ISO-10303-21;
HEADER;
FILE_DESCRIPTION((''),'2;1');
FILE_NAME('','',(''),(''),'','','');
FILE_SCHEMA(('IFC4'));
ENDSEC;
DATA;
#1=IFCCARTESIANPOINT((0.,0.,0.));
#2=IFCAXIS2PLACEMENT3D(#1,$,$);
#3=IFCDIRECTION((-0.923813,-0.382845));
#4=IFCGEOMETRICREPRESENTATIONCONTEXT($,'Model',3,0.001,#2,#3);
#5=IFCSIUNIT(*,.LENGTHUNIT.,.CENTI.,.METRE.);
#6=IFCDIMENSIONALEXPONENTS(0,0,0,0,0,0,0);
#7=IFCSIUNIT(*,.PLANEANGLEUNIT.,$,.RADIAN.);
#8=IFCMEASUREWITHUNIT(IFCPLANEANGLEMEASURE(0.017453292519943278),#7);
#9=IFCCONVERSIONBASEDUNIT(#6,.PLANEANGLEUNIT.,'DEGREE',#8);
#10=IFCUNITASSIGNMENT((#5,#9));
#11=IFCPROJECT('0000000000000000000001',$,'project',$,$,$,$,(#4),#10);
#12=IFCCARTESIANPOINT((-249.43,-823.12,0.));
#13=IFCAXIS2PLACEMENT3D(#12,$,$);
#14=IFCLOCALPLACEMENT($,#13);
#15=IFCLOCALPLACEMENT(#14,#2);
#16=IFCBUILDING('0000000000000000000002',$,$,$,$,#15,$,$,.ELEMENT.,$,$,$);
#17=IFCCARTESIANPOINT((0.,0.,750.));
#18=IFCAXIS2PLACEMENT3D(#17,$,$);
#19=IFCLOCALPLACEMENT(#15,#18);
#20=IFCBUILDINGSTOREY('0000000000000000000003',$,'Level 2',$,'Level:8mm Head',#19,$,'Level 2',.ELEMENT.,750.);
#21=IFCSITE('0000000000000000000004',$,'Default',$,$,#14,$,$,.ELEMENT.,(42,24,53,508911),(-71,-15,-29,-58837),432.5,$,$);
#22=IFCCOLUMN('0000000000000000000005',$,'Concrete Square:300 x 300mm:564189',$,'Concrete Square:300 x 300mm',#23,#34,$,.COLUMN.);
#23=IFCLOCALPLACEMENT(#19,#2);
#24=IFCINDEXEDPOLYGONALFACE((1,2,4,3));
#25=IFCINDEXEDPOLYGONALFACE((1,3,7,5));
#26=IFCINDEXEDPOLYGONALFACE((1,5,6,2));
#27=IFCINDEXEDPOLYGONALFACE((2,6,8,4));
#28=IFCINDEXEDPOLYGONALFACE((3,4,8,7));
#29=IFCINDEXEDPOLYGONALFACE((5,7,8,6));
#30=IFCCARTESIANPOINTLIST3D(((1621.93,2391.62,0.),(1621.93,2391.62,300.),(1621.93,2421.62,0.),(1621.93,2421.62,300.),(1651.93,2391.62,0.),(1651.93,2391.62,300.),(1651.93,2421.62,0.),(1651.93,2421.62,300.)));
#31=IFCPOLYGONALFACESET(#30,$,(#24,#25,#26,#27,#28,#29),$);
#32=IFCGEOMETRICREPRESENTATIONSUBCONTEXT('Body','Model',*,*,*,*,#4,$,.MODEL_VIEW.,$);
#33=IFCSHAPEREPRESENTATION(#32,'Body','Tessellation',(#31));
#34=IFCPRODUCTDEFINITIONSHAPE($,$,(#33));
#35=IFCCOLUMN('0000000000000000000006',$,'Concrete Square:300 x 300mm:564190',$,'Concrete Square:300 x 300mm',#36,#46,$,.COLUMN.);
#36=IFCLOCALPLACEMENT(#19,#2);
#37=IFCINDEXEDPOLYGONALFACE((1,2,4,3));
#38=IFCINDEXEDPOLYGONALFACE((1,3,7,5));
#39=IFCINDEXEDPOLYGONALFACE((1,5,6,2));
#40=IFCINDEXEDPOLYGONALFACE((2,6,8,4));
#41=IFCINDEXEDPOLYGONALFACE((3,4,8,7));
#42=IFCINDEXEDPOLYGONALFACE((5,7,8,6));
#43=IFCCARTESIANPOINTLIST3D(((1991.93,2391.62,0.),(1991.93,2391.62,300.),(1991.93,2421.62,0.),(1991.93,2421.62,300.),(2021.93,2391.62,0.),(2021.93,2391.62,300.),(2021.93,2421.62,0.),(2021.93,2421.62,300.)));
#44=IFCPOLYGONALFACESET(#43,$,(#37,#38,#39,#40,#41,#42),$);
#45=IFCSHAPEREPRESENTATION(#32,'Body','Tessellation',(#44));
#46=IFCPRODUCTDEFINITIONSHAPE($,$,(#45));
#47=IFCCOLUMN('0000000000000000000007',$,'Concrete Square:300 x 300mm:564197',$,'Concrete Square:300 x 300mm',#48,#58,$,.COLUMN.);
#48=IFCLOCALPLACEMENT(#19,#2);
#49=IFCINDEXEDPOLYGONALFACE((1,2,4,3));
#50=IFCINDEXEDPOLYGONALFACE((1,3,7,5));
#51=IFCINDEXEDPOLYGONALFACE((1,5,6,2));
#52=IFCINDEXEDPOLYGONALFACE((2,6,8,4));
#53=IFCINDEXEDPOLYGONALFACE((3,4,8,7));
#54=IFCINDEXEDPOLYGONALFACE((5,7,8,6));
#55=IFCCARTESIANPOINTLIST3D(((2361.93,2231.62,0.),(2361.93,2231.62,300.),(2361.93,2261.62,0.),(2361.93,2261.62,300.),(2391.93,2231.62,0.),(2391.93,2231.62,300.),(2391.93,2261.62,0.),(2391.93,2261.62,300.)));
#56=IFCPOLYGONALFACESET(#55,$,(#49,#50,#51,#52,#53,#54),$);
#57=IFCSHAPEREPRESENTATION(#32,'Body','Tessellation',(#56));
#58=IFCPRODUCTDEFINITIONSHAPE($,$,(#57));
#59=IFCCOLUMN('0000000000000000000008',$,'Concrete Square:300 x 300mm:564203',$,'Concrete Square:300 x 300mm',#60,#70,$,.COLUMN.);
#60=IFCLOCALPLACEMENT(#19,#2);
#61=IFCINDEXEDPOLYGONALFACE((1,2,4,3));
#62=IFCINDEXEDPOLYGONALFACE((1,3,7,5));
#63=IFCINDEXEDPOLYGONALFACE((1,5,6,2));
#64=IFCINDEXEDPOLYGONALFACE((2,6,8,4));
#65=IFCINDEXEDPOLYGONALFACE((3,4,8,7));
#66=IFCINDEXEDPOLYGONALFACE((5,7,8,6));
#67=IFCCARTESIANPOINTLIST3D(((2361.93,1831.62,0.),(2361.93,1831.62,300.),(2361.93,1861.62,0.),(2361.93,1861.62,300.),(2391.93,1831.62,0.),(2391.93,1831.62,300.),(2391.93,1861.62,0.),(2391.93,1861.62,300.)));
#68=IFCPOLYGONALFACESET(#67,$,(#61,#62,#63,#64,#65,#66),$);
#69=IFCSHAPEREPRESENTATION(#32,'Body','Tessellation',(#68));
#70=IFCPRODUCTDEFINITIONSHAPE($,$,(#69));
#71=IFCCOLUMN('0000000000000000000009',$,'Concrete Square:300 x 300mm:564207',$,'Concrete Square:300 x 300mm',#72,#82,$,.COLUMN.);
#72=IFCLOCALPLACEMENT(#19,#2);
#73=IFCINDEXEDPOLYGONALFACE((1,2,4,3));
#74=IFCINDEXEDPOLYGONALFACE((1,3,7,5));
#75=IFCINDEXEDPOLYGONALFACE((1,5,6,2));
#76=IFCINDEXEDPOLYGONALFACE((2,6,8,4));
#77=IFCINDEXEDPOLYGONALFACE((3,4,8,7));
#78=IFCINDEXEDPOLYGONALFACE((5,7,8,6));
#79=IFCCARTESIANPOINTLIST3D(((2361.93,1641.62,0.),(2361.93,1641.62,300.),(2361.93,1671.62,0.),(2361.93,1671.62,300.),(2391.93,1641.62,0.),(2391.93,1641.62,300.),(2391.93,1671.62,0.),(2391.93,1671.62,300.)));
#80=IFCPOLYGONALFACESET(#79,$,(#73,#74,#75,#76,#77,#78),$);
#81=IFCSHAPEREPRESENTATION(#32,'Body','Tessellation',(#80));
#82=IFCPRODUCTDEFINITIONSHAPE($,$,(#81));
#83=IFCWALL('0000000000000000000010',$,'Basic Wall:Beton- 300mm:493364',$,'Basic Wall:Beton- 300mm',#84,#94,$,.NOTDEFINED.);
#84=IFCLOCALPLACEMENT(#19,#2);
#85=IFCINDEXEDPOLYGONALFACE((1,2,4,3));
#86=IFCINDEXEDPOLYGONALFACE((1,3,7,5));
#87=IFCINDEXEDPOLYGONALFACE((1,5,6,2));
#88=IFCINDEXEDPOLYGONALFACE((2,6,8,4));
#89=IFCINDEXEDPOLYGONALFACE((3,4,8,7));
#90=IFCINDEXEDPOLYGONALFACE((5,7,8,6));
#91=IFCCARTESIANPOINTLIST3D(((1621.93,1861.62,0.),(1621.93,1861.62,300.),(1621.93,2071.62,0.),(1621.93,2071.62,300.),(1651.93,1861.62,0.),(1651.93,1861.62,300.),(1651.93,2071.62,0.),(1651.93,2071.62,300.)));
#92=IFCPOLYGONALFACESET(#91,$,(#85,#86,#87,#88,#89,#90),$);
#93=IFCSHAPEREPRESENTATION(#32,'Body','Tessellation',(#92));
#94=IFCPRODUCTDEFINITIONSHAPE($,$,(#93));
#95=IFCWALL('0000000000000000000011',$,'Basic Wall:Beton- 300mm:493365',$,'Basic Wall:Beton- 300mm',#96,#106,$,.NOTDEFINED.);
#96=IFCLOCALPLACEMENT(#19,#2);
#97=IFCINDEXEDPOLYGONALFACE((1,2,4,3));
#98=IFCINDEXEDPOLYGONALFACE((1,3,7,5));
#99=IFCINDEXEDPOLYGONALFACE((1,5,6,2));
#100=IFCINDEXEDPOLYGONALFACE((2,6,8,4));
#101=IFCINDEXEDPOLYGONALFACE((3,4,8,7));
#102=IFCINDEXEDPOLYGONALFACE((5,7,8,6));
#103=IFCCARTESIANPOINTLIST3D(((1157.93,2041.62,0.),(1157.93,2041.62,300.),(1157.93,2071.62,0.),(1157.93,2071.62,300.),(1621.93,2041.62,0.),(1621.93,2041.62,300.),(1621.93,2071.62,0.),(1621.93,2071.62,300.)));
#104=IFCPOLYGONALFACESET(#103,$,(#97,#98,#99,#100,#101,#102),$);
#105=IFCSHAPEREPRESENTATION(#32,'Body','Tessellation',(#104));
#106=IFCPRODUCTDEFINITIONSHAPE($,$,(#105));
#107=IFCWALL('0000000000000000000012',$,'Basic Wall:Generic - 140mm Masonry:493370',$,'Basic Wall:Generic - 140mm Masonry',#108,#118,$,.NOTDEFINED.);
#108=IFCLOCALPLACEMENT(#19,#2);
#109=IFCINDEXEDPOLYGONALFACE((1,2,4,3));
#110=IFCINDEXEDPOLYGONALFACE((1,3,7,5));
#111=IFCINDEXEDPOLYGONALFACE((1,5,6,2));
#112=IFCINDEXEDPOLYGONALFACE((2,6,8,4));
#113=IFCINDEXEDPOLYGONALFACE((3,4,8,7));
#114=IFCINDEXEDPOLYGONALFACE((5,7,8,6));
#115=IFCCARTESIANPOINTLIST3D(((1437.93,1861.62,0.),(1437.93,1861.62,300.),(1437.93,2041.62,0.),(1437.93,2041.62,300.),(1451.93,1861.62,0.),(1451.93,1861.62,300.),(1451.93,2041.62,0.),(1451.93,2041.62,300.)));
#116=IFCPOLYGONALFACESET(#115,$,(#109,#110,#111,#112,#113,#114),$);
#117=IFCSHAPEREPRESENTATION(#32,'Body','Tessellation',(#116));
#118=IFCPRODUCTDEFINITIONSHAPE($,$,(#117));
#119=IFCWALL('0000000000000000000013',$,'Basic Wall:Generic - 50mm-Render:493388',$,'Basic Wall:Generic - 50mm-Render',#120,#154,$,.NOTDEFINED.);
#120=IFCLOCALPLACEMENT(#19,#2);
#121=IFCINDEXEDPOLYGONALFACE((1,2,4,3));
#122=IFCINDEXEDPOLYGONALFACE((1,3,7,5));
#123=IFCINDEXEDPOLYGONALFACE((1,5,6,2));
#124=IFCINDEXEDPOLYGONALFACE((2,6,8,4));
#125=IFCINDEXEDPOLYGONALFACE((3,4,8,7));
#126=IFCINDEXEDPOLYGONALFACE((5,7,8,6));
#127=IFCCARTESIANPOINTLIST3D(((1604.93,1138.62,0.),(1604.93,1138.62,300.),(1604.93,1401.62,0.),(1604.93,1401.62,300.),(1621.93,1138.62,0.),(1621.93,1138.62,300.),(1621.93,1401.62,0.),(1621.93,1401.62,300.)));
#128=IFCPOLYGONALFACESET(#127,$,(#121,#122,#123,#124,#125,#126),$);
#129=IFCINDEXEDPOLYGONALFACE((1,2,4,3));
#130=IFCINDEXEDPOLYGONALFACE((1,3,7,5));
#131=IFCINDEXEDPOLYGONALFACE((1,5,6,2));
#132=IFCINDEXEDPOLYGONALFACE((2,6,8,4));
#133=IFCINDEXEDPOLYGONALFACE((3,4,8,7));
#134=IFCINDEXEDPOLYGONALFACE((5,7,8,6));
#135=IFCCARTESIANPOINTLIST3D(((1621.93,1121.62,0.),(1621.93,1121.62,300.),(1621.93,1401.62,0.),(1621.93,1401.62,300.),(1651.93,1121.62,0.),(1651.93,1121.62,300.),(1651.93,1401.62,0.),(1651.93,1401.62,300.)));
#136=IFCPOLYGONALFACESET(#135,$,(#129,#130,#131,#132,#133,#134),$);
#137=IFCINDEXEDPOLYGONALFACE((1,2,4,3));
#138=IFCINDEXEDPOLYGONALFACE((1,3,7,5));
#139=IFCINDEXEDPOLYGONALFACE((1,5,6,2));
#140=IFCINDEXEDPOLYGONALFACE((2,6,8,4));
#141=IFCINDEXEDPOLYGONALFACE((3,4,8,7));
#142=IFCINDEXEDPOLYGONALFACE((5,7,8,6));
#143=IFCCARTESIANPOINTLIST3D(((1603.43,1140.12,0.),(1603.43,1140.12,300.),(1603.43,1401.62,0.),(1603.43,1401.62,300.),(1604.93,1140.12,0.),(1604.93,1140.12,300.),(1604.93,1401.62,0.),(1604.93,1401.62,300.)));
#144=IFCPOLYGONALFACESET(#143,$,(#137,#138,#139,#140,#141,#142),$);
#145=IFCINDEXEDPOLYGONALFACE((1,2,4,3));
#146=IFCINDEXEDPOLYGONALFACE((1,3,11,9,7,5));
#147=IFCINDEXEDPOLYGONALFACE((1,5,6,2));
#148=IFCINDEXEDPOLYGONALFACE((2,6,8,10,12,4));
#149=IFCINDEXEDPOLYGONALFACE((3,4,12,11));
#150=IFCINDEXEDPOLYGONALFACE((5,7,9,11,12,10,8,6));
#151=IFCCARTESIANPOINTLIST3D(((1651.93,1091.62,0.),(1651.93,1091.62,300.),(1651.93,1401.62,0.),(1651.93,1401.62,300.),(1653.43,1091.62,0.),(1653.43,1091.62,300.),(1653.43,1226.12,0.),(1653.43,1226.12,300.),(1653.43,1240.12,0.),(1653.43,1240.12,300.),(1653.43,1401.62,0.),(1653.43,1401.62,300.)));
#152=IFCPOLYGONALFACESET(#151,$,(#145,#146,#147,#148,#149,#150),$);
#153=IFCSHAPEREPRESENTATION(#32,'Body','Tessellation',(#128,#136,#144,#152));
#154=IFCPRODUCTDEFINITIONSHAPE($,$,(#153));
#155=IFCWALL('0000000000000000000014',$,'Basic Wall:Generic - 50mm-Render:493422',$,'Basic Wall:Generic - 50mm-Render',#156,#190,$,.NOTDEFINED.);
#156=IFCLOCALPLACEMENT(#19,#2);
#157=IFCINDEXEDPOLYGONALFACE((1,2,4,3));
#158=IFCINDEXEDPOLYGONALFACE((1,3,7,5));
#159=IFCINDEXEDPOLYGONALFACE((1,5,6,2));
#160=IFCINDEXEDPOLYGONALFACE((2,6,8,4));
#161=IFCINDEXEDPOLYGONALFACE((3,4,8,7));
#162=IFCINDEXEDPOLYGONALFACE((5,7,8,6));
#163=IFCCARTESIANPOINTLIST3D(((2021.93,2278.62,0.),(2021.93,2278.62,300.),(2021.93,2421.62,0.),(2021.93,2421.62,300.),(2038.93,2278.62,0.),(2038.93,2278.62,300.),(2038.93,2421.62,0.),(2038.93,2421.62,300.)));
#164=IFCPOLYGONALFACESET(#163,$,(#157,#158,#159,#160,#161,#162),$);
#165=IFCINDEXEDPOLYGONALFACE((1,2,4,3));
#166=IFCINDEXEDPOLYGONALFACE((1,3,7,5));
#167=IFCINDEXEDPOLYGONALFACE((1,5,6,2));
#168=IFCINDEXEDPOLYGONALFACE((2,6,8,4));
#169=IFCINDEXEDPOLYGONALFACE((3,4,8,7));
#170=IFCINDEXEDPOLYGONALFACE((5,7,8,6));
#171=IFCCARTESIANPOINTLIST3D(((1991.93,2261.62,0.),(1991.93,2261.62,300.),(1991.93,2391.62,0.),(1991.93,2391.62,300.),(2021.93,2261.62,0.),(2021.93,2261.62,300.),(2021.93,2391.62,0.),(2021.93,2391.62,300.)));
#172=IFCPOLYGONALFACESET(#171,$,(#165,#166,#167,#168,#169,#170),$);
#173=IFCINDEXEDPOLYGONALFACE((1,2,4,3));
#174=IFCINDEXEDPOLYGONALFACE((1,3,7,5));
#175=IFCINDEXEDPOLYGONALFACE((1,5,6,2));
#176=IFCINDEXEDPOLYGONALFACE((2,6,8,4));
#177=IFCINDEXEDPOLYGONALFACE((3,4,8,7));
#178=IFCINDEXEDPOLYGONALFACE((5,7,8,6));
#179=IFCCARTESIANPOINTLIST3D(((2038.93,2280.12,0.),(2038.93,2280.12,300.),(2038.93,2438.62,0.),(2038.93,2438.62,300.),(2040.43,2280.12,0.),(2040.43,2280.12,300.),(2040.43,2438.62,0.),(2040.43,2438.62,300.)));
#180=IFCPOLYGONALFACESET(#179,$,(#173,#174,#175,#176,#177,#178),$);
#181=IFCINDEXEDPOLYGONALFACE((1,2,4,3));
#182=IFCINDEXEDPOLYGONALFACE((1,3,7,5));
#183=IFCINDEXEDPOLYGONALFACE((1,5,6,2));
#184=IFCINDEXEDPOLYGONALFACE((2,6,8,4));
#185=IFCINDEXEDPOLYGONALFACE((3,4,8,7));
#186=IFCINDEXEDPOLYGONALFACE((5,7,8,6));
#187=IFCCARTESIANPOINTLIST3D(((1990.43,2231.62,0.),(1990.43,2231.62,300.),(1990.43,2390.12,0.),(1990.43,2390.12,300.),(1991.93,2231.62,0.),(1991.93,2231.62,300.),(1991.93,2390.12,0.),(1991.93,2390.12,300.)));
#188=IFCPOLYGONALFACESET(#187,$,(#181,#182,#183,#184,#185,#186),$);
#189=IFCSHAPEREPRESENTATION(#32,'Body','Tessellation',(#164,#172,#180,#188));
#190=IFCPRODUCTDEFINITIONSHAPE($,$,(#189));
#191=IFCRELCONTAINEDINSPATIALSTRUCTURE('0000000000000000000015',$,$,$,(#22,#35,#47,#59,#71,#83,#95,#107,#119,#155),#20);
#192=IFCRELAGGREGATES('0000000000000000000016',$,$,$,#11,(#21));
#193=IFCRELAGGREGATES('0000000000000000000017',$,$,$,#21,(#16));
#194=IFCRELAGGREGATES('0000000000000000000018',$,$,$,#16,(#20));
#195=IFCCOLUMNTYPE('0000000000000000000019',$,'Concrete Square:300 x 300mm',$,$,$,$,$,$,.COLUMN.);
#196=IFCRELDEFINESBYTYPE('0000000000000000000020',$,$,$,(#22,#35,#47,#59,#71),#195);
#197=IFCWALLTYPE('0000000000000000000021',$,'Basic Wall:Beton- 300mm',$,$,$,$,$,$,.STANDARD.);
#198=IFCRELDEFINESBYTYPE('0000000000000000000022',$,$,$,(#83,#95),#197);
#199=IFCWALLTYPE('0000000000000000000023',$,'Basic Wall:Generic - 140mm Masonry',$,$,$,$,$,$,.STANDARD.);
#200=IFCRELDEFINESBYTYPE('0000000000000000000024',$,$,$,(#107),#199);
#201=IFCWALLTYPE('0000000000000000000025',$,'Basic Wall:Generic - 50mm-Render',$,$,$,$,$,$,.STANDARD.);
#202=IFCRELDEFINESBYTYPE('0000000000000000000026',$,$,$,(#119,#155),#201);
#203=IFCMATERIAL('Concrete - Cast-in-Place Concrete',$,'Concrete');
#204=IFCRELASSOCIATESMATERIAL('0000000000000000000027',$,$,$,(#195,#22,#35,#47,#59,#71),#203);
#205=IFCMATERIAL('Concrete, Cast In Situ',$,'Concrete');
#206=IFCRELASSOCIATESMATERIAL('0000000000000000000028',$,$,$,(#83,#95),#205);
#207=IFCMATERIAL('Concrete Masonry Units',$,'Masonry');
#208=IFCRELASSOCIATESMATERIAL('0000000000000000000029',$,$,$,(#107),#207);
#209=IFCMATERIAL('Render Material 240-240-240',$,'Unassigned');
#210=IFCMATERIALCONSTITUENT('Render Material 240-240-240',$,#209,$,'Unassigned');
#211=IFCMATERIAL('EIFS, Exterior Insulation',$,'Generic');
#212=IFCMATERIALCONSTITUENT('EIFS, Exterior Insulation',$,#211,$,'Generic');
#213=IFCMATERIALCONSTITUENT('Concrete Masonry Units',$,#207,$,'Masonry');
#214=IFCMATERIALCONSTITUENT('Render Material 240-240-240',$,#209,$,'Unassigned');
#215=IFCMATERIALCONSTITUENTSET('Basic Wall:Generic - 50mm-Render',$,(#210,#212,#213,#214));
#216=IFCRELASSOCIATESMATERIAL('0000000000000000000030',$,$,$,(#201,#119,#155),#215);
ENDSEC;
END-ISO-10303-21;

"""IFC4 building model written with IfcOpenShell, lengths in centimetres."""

from ifc_helpers import new_model, entity, si_unit, converted_unit, direction, frame, origin, place, context, subcontext, project, spatial, indexed_curve, outline, extrude, source, transform, mapped, material, constituent, constituent_set, type_object, type_shapes, element, save


model = new_model("IFC4")

# Units and contexts
model_context = context("Model", 3, precision=0.001, world=origin(), true_north=direction((-0.923813, -0.382845)))
body_context = subcontext(model_context, "Body", "Model", "MODEL_VIEW")
ifc_project = project(units=[si_unit("LENGTHUNIT", "METRE", prefix="CENTI"), converted_unit("PLANEANGLEUNIT", "DEGREE", entity("IfcPlaneAngleMeasure", 0.017453292519943278), si_unit("PLANEANGLEUNIT", "RADIAN"), dimensions=[0, 0, 0, 0, 0, 0, 0])], contexts=[model_context])

# Site, building, storey
site_placement = place(None, frame((-249.43, -823.12, 0.0)))
site = spatial("IfcSite", under=ifc_project, at=site_placement, Name="Default", CompositionType="ELEMENT", RefLatitude=(42, 24, 53, 508911), RefLongitude=(-71, -15, -29, -58837), RefElevation=432.5)
building_placement = place(site_placement, origin())
building = spatial("IfcBuilding", under=site, at=building_placement, CompositionType="ELEMENT")
storey_placement = place(building_placement, frame((0.0, 0.0, 750.0)))
storey = spatial("IfcBuildingStorey", under=building, at=storey_placement, Name="Level 2", ObjectType="Level:8mm Head", LongName="Level 2", CompositionType="ELEMENT", Elevation=750.0)

# Columns
ifc_material_1 = material(Name="Concrete - Cast-in-Place Concrete", Category="Concrete")
column_type = type_object("IfcColumnType", Name="Concrete Square:300 x 300mm", PredefinedType="COLUMN", material=ifc_material_1)
shared_shape_1 = source(origin(), body_context, "Body", "SweptSolid", [
    extrude(outline(indexed_curve([(-15.0, -15.0), (15.0, -15.0), (15.0, 15.0), (-15.0, 15.0), (-15.0, -15.0)], self_intersect=False)), frame((0.0, 0.0, 750.0), z_axis=(0.0, 0.0, 1.0), x_axis=(-1.0, 0.0, 0.0)), (0.0, 0.0, 1.0), 300.0),
])
type_shapes(column_type, [shared_shape_1])
for number, where, name in (
    (1, (1636.93, 2406.62, -750.0), "Concrete Square:300 x 300mm:564189"),
    (2, (2006.93, 2406.62, -750.0), "Concrete Square:300 x 300mm:564190"),
    (3, (2376.93, 2246.62, -750.0), "Concrete Square:300 x 300mm:564197"),
    (4, (2376.93, 1846.62, -750.0), "Concrete Square:300 x 300mm:564203"),
    (5, (2376.93, 1656.62, -750.0), "Concrete Square:300 x 300mm:564207"),
):
    element("IfcColumn", number, at=place(storey_placement, frame(where)), inside=storey, type_object=column_type, material=ifc_material_1, Name=name, ObjectType="Concrete Square:300 x 300mm", PredefinedType="COLUMN", context=body_context, shape_type="MappedRepresentation", body=[
        mapped(shared_shape_1, transform((0.0, 0.0, 0.0), scale=1.0)),
    ])

# Walls
ifc_material_2 = material(Name="Concrete, Cast In Situ", Category="Concrete")
wall_type_1 = type_object("IfcWallType", Name="Basic Wall:Beton- 300mm", PredefinedType="STANDARD")
wall_1_placement = place(storey_placement, frame((1636.93, 1861.62, 0.0), z_axis=(0.0, 0.0, 1.0), x_axis=(0.0, 1.0, 0.0)))
element("IfcWall", 6, at=wall_1_placement, inside=storey, type_object=wall_type_1, material=ifc_material_2, Name="Basic Wall:Beton- 300mm:493364", ObjectType="Basic Wall:Beton- 300mm", PredefinedType="NOTDEFINED", context=body_context, shape_type="SweptSolid", body=[
    extrude(outline(indexed_curve([(210.0, 15.0), (0.0, 15.0), (0.0, -15.0), (210.0, -15.0), (210.0, 15.0)], self_intersect=False)), origin(), (0.0, 0.0, 1.0), 300.0),
])
wall_2_placement = place(storey_placement, frame((1621.93, 2056.62, 0.0), z_axis=(0.0, 0.0, 1.0), x_axis=(-1.0, 0.0, 0.0)))
element("IfcWall", 7, at=wall_2_placement, inside=storey, type_object=wall_type_1, material=ifc_material_2, Name="Basic Wall:Beton- 300mm:493365", ObjectType="Basic Wall:Beton- 300mm", PredefinedType="NOTDEFINED", context=body_context, shape_type="SweptSolid", body=[
    extrude(outline(indexed_curve([(464.0, 15.0), (0.0, 15.0), (0.0, -15.0), (464.0, -15.0), (464.0, 15.0)], self_intersect=False)), origin(), (0.0, 0.0, 1.0), 300.0),
])
ifc_material_3 = material(Name="Concrete Masonry Units", Category="Masonry")
wall_type_2 = type_object("IfcWallType", Name="Basic Wall:Generic - 140mm Masonry", PredefinedType="STANDARD")
wall_3_placement = place(storey_placement, frame((1444.93, 2041.62, 0.0), z_axis=(0.0, 0.0, 1.0), x_axis=(0.0, -1.0, 0.0)))
element("IfcWall", 8, at=wall_3_placement, inside=storey, type_object=wall_type_2, material=ifc_material_3, Name="Basic Wall:Generic - 140mm Masonry:493370", ObjectType="Basic Wall:Generic - 140mm Masonry", PredefinedType="NOTDEFINED", context=body_context, shape_type="SweptSolid", body=[
    extrude(outline(indexed_curve([(180.0, 7.0), (0.0, 7.0), (0.0, -7.0), (180.0, -7.0), (180.0, 7.0)], self_intersect=False)), origin(), (0.0, 0.0, 1.0), 300.0),
])
ifc_material_4 = material(Name="Render Material 240-240-240", Category="Unassigned")
ifc_constituent_1 = constituent(ifc_material_4, Name="Render Material 240-240-240", Category="Unassigned")
ifc_material_5 = material(Name="EIFS, Exterior Insulation", Category="Generic")
ifc_constituent_2 = constituent(ifc_material_5, Name="EIFS, Exterior Insulation", Category="Generic")
ifc_constituent_3 = constituent(ifc_material_3, Name="Concrete Masonry Units", Category="Masonry")
ifc_constituent_4 = constituent(ifc_material_4, Name="Render Material 240-240-240", Category="Unassigned")
ifc_constituent_set_1 = constituent_set(constituents=[ifc_constituent_1, ifc_constituent_2, ifc_constituent_3, ifc_constituent_4], Name="Basic Wall:Generic - 50mm-Render")
wall_type_3 = type_object("IfcWallType", Name="Basic Wall:Generic - 50mm-Render", PredefinedType="STANDARD", material=ifc_constituent_set_1)
wall_4_placement = place(storey_placement, frame((1628.43, 1401.62, 0.0), z_axis=(0.0, 0.0, 1.0), x_axis=(0.0, -1.0, 0.0)))
element("IfcWall", 9, at=wall_4_placement, inside=storey, type_object=wall_type_3, material=ifc_constituent_set_1, Name="Basic Wall:Generic - 50mm-Render:493388", ObjectType="Basic Wall:Generic - 50mm-Render", PredefinedType="NOTDEFINED", context=body_context, shape_type="SweptSolid", body=[
    extrude(outline(indexed_curve([(-8.5, -131.5), (8.5, -131.5), (8.5, 131.5), (-8.5, 131.5), (-8.5, -131.5)], self_intersect=False)), frame((131.5, -15.0, 0.0), z_axis=(0.0, 0.0, 1.0), x_axis=(0.0, 1.0, 0.0)), (0.0, 0.0, 1.0), 300.0),
    extrude(outline(indexed_curve([(-15.0, -140.0), (15.0, -140.0), (15.0, 140.0), (-15.0, 140.0), (-15.0, -140.0)], self_intersect=False)), frame((140.0, 8.5, 0.0), z_axis=(0.0, 0.0, 1.0), x_axis=(0.0, -1.0, 0.0)), (0.0, 0.0, 1.0), 300.0),
    extrude(outline(indexed_curve([(-0.75, -130.75), (0.75, -130.75), (0.75, 130.75), (-0.75, 130.75), (-0.75, -130.75)], self_intersect=False)), frame((130.75, -24.25, 0.0), z_axis=(0.0, 0.0, 1.0), x_axis=(0.0, 1.0, 0.0)), (0.0, 0.0, 1.0), 300.0),
    extrude(outline(indexed_curve([(-1.0, -150.5), (0.5, -150.5), (0.5, -16.0), (0.5, -2.0), (0.5, 159.5), (-1.0, 159.5), (-1.0, -150.5)], self_intersect=False)), frame((159.5, 24.5, 0.0), z_axis=(0.0, 0.0, 1.0), x_axis=(0.0, 1.0, 0.0)), (0.0, 0.0, 1.0), 300.0),
])
wall_5_placement = place(storey_placement, frame((2015.43, 2280.12, 0.0), z_axis=(0.0, 0.0, 1.0), x_axis=(0.0, 1.0, 0.0)))
element("IfcWall", 10, at=wall_5_placement, inside=storey, type_object=wall_type_3, material=ifc_constituent_set_1, Name="Basic Wall:Generic - 50mm-Render:493422", ObjectType="Basic Wall:Generic - 50mm-Render", PredefinedType="NOTDEFINED", context=body_context, shape_type="SweptSolid", body=[
    extrude(outline(indexed_curve([(-8.5, -71.5), (8.5, -71.5), (8.5, 71.5), (-8.5, 71.5), (-8.5, -71.5)], self_intersect=False)), frame((70.0, -15.0, 0.0), z_axis=(0.0, 0.0, 1.0), x_axis=(0.0, 1.0, 0.0)), (0.0, 0.0, 1.0), 300.0),
    extrude(outline(indexed_curve([(-15.0, -65.0), (15.0, -65.0), (15.0, 65.0), (-15.0, 65.0), (-15.0, -65.0)], self_intersect=False)), frame((46.5, 8.5, 0.0), z_axis=(0.0, 0.0, 1.0), x_axis=(0.0, -1.0, 0.0)), (0.0, 0.0, 1.0), 300.0),
    extrude(outline(indexed_curve([(-0.75, -79.25), (0.75, -79.25), (0.75, 79.25), (-0.75, 79.25), (-0.75, -79.25)], self_intersect=False)), frame((79.25, -24.25, 0.0), z_axis=(0.0, 0.0, 1.0), x_axis=(0.0, 1.0, 0.0)), (0.0, 0.0, 1.0), 300.0),
    extrude(outline(indexed_curve([(-0.75, -79.25), (0.75, -79.25), (0.75, 79.25), (-0.75, 79.25), (-0.75, -79.25)], self_intersect=False)), frame((30.75, 24.25, 0.0), z_axis=(0.0, 0.0, 1.0), x_axis=(0.0, 1.0, 0.0)), (0.0, 0.0, 1.0), 300.0),
])

save(model, "model.ifc")
